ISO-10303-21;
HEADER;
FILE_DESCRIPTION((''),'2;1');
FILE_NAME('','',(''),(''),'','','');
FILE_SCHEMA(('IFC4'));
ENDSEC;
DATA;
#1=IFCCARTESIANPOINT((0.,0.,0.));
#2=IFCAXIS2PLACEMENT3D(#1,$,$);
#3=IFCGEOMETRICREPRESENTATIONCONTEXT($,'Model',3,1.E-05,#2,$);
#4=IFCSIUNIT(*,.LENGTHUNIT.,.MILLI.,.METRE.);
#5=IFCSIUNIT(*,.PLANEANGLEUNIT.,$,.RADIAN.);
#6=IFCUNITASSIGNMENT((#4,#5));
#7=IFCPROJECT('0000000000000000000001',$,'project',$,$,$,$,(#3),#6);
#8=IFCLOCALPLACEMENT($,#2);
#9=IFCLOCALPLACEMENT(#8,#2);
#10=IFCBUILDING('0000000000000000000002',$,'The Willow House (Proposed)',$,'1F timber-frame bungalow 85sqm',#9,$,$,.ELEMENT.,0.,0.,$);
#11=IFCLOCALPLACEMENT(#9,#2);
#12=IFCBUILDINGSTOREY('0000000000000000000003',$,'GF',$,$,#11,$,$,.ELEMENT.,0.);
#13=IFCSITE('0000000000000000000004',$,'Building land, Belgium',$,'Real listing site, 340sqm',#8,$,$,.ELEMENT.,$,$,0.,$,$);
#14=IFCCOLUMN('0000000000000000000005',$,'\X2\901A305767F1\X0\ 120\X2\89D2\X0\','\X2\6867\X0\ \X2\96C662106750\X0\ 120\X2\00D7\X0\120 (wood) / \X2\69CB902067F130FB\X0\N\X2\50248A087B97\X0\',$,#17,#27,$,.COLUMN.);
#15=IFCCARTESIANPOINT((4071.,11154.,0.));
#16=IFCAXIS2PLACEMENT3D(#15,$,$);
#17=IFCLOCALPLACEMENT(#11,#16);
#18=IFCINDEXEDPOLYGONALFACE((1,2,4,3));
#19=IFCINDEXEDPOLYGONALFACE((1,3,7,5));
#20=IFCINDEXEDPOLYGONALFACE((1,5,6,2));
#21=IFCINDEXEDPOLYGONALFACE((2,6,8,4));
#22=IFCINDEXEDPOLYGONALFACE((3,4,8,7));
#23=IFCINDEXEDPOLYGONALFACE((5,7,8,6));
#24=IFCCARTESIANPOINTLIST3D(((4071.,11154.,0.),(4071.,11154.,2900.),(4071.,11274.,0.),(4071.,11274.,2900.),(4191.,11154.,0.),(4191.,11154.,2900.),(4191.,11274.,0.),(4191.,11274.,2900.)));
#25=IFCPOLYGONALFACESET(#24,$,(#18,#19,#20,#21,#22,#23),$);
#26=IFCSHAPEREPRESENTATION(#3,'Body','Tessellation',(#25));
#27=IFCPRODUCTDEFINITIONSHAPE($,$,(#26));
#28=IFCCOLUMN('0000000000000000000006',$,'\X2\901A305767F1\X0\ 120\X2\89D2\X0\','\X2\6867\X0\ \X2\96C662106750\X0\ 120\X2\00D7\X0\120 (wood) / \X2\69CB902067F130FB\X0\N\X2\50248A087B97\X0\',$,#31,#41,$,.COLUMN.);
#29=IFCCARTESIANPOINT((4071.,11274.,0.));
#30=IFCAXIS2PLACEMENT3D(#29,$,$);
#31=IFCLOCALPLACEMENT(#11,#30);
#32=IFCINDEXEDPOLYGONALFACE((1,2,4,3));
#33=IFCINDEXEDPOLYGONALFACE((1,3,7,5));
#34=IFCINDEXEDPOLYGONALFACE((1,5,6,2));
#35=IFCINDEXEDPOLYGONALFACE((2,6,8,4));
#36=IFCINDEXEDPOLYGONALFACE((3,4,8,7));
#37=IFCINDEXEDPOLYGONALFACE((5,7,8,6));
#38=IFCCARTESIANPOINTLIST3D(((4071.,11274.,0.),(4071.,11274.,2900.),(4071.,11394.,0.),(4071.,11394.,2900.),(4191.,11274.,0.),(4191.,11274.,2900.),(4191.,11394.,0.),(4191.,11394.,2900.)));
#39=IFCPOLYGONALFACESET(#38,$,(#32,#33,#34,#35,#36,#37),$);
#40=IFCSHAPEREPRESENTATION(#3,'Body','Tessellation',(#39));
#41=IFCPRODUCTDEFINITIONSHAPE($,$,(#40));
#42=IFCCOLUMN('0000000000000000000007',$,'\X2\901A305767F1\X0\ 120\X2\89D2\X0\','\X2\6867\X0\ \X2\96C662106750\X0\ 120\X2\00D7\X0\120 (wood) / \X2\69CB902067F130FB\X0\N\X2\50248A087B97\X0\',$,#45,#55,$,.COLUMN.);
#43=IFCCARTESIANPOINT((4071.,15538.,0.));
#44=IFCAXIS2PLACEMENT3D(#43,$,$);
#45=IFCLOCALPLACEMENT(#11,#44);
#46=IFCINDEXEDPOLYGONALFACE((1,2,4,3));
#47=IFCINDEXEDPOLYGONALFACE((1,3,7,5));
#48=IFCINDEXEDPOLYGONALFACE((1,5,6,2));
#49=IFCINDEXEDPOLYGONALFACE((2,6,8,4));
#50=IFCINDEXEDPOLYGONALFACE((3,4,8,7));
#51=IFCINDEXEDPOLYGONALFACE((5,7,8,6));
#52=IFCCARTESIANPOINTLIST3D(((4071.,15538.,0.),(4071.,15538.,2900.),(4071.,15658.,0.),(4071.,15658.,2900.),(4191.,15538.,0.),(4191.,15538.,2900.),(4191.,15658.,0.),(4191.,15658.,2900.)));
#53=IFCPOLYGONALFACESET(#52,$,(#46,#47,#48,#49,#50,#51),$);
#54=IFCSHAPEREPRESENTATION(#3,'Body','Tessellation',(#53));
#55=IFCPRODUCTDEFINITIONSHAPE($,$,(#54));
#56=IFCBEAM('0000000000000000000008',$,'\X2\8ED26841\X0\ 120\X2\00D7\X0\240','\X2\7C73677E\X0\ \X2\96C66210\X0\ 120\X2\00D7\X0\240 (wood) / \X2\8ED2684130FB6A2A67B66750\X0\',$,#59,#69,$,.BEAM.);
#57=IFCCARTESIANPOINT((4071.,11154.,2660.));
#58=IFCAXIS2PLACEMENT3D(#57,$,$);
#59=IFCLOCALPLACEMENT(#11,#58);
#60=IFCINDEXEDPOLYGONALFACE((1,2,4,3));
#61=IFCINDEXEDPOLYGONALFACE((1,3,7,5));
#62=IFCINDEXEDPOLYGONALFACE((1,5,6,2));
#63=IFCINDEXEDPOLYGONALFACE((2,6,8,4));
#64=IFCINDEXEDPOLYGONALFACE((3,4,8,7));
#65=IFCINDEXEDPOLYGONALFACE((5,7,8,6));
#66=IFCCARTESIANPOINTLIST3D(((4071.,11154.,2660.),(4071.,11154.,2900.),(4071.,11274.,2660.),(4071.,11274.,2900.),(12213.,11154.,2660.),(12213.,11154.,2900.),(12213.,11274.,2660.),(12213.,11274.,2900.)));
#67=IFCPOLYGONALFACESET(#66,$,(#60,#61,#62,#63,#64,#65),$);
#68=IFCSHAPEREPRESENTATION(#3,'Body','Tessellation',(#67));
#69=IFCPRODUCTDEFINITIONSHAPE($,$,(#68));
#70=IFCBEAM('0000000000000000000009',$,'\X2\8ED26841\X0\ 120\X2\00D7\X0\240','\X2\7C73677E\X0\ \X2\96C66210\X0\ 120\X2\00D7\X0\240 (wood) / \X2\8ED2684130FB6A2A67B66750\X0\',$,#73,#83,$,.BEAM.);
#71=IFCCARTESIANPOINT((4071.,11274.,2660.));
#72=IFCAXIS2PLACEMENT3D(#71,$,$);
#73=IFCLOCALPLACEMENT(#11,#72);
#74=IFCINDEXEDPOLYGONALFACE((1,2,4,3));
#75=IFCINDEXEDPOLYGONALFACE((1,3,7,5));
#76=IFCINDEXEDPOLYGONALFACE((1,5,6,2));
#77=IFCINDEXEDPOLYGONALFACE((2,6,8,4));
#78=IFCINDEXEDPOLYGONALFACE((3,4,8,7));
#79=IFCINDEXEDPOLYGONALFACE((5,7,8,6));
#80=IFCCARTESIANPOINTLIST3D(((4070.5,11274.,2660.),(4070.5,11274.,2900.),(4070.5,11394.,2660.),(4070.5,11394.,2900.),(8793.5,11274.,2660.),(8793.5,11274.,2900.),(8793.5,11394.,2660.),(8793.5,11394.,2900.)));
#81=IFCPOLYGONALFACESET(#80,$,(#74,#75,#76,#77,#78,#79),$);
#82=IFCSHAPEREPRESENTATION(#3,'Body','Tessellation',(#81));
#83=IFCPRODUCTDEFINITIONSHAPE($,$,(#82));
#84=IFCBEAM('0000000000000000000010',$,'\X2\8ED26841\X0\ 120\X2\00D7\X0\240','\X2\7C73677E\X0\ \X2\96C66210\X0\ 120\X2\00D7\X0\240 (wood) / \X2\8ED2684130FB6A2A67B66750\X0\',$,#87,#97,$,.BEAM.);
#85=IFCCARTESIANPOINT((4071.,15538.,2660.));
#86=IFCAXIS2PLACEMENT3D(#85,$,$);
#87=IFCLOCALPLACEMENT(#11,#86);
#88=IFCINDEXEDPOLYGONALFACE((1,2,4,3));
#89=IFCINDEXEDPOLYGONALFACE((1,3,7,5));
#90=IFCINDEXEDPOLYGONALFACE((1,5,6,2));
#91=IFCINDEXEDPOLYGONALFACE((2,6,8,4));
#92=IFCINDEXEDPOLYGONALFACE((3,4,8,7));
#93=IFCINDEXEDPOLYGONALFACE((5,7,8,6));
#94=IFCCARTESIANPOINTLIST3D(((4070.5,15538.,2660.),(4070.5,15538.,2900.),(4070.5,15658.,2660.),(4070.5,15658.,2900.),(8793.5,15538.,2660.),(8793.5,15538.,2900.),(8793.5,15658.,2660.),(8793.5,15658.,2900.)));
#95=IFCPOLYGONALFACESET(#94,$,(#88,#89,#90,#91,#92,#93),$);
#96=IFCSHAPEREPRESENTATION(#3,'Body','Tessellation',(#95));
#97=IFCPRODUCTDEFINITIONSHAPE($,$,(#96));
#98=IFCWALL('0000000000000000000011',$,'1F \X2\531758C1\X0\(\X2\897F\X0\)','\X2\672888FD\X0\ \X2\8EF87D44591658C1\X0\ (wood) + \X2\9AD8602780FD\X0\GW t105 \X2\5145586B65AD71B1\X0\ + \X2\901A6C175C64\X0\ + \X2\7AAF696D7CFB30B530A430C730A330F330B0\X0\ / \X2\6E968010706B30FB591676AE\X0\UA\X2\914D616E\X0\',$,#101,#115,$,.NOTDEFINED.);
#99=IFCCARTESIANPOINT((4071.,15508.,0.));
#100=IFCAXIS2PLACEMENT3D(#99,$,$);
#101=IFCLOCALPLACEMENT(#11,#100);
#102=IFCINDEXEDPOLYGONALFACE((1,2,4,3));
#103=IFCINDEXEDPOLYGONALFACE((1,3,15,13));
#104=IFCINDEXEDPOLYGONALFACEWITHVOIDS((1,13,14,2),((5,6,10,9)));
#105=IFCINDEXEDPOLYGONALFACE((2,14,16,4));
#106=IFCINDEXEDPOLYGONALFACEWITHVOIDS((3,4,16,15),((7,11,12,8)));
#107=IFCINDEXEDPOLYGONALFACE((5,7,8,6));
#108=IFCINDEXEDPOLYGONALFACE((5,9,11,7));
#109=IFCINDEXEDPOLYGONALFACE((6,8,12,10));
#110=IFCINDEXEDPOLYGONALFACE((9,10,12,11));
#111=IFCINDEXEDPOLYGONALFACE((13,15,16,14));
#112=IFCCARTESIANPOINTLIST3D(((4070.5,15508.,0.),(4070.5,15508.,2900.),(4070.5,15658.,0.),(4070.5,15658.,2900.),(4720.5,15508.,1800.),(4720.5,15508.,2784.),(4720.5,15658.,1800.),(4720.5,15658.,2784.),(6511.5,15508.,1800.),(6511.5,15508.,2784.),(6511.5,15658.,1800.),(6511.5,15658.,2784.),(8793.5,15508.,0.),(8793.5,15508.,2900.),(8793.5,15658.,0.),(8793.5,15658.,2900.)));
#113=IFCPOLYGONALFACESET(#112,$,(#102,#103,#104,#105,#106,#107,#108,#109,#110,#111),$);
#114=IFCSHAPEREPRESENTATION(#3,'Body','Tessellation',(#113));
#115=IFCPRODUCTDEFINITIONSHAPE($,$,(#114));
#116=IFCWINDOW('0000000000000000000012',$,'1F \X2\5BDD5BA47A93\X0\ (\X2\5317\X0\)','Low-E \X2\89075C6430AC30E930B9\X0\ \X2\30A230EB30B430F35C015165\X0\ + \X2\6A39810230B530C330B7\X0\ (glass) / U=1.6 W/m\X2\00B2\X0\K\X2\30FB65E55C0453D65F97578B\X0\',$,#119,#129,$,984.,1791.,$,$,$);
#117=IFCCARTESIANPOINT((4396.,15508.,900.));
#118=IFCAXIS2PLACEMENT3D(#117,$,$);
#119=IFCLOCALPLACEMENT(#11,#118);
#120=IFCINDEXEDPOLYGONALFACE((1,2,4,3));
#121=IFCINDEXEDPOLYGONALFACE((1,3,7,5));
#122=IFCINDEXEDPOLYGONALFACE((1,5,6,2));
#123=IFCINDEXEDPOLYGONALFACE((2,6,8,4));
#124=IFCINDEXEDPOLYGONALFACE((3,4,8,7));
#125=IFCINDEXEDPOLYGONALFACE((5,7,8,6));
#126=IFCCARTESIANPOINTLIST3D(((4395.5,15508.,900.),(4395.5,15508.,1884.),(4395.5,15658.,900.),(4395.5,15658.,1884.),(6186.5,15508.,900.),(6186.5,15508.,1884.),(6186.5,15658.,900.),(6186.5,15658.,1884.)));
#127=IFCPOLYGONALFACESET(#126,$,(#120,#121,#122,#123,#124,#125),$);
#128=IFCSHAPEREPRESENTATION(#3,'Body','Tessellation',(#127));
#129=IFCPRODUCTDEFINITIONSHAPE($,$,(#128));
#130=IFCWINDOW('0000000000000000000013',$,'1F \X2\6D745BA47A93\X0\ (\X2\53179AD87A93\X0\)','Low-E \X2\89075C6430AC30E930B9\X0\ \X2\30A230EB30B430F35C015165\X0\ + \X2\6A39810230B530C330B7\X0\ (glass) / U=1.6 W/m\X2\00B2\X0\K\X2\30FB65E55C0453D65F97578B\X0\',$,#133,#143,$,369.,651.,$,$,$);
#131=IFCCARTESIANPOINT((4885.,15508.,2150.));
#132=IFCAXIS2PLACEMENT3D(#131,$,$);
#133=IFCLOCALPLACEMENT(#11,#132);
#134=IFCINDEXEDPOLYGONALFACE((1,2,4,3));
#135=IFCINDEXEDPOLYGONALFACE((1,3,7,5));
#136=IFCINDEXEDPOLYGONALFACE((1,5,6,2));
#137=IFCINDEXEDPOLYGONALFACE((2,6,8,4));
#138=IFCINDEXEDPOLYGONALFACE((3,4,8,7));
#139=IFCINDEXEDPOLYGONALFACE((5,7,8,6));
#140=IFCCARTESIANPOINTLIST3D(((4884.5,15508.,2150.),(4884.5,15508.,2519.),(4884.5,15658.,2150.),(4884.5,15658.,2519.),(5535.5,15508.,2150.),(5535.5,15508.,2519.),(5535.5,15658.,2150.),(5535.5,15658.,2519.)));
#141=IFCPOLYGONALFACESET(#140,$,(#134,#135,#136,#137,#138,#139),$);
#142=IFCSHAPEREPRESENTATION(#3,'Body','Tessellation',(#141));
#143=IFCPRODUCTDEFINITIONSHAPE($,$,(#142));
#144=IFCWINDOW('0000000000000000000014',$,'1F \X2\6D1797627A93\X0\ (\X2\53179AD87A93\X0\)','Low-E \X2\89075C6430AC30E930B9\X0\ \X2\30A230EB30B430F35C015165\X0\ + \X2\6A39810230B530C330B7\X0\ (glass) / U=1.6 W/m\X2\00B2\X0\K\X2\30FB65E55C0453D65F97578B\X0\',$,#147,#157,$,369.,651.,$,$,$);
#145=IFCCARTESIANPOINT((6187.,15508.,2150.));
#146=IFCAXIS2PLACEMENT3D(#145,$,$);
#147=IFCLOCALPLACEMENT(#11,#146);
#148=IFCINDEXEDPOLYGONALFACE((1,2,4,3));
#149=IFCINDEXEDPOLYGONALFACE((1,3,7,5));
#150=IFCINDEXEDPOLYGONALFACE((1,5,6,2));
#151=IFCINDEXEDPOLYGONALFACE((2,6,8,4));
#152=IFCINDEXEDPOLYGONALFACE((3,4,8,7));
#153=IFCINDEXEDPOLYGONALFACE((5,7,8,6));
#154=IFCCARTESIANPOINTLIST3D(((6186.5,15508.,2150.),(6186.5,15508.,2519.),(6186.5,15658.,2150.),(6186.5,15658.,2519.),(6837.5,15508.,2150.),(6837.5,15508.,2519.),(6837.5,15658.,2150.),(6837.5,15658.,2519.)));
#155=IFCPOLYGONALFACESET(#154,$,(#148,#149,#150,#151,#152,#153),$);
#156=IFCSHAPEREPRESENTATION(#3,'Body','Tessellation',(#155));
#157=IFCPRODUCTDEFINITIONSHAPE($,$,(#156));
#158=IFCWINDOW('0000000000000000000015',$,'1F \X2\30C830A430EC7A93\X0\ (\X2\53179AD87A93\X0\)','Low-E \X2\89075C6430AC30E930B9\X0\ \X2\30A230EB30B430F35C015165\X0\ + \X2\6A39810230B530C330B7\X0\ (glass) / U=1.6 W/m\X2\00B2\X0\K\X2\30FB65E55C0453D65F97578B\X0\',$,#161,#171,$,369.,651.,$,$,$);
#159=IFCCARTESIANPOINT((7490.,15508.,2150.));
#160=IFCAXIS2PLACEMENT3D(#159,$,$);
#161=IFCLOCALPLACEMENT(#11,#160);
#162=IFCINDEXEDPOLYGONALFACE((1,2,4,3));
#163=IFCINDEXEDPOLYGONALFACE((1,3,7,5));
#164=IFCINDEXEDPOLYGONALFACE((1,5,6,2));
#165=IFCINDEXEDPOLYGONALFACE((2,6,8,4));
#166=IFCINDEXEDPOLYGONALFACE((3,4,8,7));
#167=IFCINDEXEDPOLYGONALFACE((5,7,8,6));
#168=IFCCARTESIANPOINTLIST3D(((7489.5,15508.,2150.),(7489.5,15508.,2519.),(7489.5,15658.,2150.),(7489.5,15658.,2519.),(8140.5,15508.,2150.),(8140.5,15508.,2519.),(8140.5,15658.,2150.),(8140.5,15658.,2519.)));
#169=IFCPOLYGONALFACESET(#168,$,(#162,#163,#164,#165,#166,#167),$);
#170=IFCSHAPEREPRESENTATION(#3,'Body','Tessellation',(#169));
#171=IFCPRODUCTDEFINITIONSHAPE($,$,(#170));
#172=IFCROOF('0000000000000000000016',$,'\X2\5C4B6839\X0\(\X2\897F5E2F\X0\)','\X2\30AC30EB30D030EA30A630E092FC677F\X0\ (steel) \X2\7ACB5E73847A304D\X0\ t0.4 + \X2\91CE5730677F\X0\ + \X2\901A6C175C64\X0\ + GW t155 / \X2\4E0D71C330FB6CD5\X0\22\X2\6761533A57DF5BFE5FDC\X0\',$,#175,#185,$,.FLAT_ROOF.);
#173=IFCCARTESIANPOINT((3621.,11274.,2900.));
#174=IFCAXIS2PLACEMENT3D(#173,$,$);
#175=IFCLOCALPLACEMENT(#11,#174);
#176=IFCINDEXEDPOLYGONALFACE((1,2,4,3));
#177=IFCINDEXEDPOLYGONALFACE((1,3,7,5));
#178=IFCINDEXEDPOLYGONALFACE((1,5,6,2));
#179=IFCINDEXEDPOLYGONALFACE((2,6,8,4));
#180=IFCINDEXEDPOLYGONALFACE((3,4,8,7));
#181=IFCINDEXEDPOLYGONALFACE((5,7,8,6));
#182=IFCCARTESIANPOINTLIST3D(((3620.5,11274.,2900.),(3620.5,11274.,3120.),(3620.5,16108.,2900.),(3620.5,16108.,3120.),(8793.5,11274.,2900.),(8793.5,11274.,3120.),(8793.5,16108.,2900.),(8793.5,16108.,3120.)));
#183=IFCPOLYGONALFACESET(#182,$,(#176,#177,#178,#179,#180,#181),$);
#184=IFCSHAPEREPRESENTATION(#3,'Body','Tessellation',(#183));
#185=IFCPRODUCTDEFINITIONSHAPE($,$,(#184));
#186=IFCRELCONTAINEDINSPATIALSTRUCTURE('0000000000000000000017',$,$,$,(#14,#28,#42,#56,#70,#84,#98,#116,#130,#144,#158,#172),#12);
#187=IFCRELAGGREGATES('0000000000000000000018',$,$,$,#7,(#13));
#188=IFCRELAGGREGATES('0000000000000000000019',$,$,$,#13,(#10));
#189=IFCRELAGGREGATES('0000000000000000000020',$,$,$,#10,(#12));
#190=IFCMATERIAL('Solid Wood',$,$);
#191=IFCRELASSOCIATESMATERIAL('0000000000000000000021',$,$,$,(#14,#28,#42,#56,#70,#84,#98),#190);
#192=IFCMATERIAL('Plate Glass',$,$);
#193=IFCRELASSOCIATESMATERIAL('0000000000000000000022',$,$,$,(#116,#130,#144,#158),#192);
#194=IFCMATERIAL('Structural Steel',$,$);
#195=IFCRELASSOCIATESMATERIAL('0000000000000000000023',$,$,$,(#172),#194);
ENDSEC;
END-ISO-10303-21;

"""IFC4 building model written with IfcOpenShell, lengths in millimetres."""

from ifc_helpers import new_model, si_unit, frame, frame_2d, origin, place, context, project, spatial, rectangle, extrude, material, element, fill, save


model = new_model("IFC4")

# Units and contexts
model_context = context("Model", 3, precision=1e-05, world=origin())
ifc_project = project(units=[si_unit("LENGTHUNIT", "METRE", prefix="MILLI"), si_unit("PLANEANGLEUNIT", "RADIAN")], contexts=[model_context])

# Site, building, storey
site_placement = place(None, origin())
site = spatial("IfcSite", under=ifc_project, at=site_placement, Name="Building land, Belgium", ObjectType="Real listing site, 340sqm", CompositionType="ELEMENT", RefElevation=0.0)
building_placement = place(site_placement, origin())
building = spatial("IfcBuilding", under=site, at=building_placement, Name="The Willow House (Proposed)", ObjectType="1F timber-frame bungalow 85sqm", CompositionType="ELEMENT", ElevationOfRefHeight=0.0, ElevationOfTerrain=0.0)
storey_placement = place(building_placement, origin())
storey = spatial("IfcBuildingStorey", under=building, at=storey_placement, Name="GF", CompositionType="ELEMENT", Elevation=0.0)

# Columns
ifc_material_1 = material(Name="Solid Wood")
column_1_placement = place(storey_placement, frame((4071.0, 11154.0, 0.0)))
element("IfcColumn", 1, at=column_1_placement, inside=storey, material=ifc_material_1, Name="通し柱 120角", Description="桧 集成材 120×120 (wood) / 構造柱・N値計算", PredefinedType="COLUMN", context=model_context, shape_type="SweptSolid", body=[
    extrude(rectangle(XDim=120.0, YDim=120.0, at=frame_2d((60.0, 60.0))), frame((4071.0, 11154.0, 0.0)), (0.0, 0.0, 1.0), 2900.0),
])
column_2_placement = place(storey_placement, frame((4071.0, 11274.0, 0.0)))
element("IfcColumn", 2, at=column_2_placement, inside=storey, material=ifc_material_1, Name="通し柱 120角", Description="桧 集成材 120×120 (wood) / 構造柱・N値計算", PredefinedType="COLUMN", context=model_context, shape_type="SweptSolid", body=[
    extrude(rectangle(XDim=120.0, YDim=120.0, at=frame_2d((60.0, 60.0))), frame((4071.0, 11274.0, 0.0)), (0.0, 0.0, 1.0), 2900.0),
])
column_3_placement = place(storey_placement, frame((4071.0, 15538.0, 0.0)))
element("IfcColumn", 3, at=column_3_placement, inside=storey, material=ifc_material_1, Name="通し柱 120角", Description="桧 集成材 120×120 (wood) / 構造柱・N値計算", PredefinedType="COLUMN", context=model_context, shape_type="SweptSolid", body=[
    extrude(rectangle(XDim=120.0, YDim=120.0, at=frame_2d((60.0, 60.0))), frame((4071.0, 15538.0, 0.0)), (0.0, 0.0, 1.0), 2900.0),
])

# Beams
beam_1_placement = place(storey_placement, frame((4071.0, 11154.0, 2660.0)))
element("IfcBeam", 4, at=beam_1_placement, inside=storey, material=ifc_material_1, Name="軒桁 120×240", Description="米松 集成 120×240 (wood) / 軒桁・横架材", PredefinedType="BEAM", context=model_context, shape_type="SweptSolid", body=[
    extrude(rectangle(XDim=8142.0, YDim=120.0, at=frame_2d((4071.0, 60.0))), frame((4071.0, 11154.0, 2660.0)), (0.0, 0.0, 1.0), 240.0),
])
beam_2_placement = place(storey_placement, frame((4071.0, 11274.0, 2660.0)))
element("IfcBeam", 5, at=beam_2_placement, inside=storey, material=ifc_material_1, Name="軒桁 120×240", Description="米松 集成 120×240 (wood) / 軒桁・横架材", PredefinedType="BEAM", context=model_context, shape_type="SweptSolid", body=[
    extrude(rectangle(XDim=4723.0, YDim=120.0, at=frame_2d((2361.0, 60.0))), frame((4071.0, 11274.0, 2660.0)), (0.0, 0.0, 1.0), 240.0),
])
beam_3_placement = place(storey_placement, frame((4071.0, 15538.0, 2660.0)))
element("IfcBeam", 6, at=beam_3_placement, inside=storey, material=ifc_material_1, Name="軒桁 120×240", Description="米松 集成 120×240 (wood) / 軒桁・横架材", PredefinedType="BEAM", context=model_context, shape_type="SweptSolid", body=[
    extrude(rectangle(XDim=4723.0, YDim=120.0, at=frame_2d((2361.0, 60.0))), frame((4071.0, 15538.0, 2660.0)), (0.0, 0.0, 1.0), 240.0),
])

# Wall, openings, windows
wall_1_placement = place(storey_placement, frame((4071.0, 15508.0, 0.0)))
wall_1 = element("IfcWall", 7, at=wall_1_placement, inside=storey, material=ifc_material_1, Name="1F 北壁(西)", Description="木製 軸組外壁 (wood) + 高性能GW t105 充填断熱 + 通気層 + 窯業系サイディング / 準耐火・外皮UA配慮", PredefinedType="NOTDEFINED", context=model_context, shape_type="SweptSolid", body=[
    extrude(rectangle(XDim=4723.0, YDim=150.0, at=frame_2d((2361.0, 75.0))), frame((4071.0, 15508.0, 0.0)), (0.0, 0.0, 1.0), 2900.0),
])
opening_1_placement = place(storey_placement, frame((4396.0, 15508.0, 900.0)))
opening_1 = element("IfcOpeningElement", 8, at=opening_1_placement, cuts=wall_1, PredefinedType="NOTDEFINED", context=model_context, shape_type="SweptSolid", body=[
    extrude(rectangle(XDim=1791.0, YDim=150.0, at=frame_2d((895.0, 75.0))), frame((4396.0, 15508.0, 900.0)), (0.0, 0.0, 1.0), 984.0),
])
opening_2_placement = place(storey_placement, frame((4885.0, 15508.0, 2150.0)))
opening_2 = element("IfcOpeningElement", 9, at=opening_2_placement, cuts=wall_1, PredefinedType="NOTDEFINED", context=model_context, shape_type="SweptSolid", body=[
    extrude(rectangle(XDim=651.0, YDim=150.0, at=frame_2d((325.0, 75.0))), frame((4885.0, 15508.0, 2150.0)), (0.0, 0.0, 1.0), 369.0),
])
opening_3_placement = place(storey_placement, frame((6187.0, 15508.0, 2150.0)))
opening_3 = element("IfcOpeningElement", 10, at=opening_3_placement, cuts=wall_1, PredefinedType="NOTDEFINED", context=model_context, shape_type="SweptSolid", body=[
    extrude(rectangle(XDim=651.0, YDim=150.0, at=frame_2d((325.0, 75.0))), frame((6187.0, 15508.0, 2150.0)), (0.0, 0.0, 1.0), 369.0),
])
opening_4_placement = place(storey_placement, frame((7490.0, 15508.0, 2150.0)))
opening_4 = element("IfcOpeningElement", 11, at=opening_4_placement, cuts=wall_1, PredefinedType="NOTDEFINED", context=model_context, shape_type="SweptSolid", body=[
    extrude(rectangle(XDim=651.0, YDim=150.0, at=frame_2d((325.0, 75.0))), frame((7490.0, 15508.0, 2150.0)), (0.0, 0.0, 1.0), 369.0),
])
ifc_material_2 = material(Name="Plate Glass")
window_1_placement = place(storey_placement, frame((4396.0, 15508.0, 900.0)))
window_1 = element("IfcWindow", 12, at=window_1_placement, inside=storey, material=ifc_material_2, Name="1F 寝室窓 (北)", Description="Low-E 複層ガラス アルゴン封入 + 樹脂サッシ (glass) / U=1.6 W/m²K・日射取得型", OverallHeight=984.0, OverallWidth=1791.0, context=model_context, shape_type="SweptSolid", body=[
    extrude(rectangle(XDim=1791.0, YDim=150.0, at=frame_2d((895.0, 75.0))), frame((4396.0, 15508.0, 900.0)), (0.0, 0.0, 1.0), 984.0),
])
fill(opening_1, window_1)
window_2_placement = place(storey_placement, frame((4885.0, 15508.0, 2150.0)))
window_2 = element("IfcWindow", 13, at=window_2_placement, inside=storey, material=ifc_material_2, Name="1F 浴室窓 (北高窓)", Description="Low-E 複層ガラス アルゴン封入 + 樹脂サッシ (glass) / U=1.6 W/m²K・日射取得型", OverallHeight=369.0, OverallWidth=651.0, context=model_context, shape_type="SweptSolid", body=[
    extrude(rectangle(XDim=651.0, YDim=150.0, at=frame_2d((325.0, 75.0))), frame((4885.0, 15508.0, 2150.0)), (0.0, 0.0, 1.0), 369.0),
])
fill(opening_2, window_2)
window_3_placement = place(storey_placement, frame((6187.0, 15508.0, 2150.0)))
window_3 = element("IfcWindow", 14, at=window_3_placement, inside=storey, material=ifc_material_2, Name="1F 洗面窓 (北高窓)", Description="Low-E 複層ガラス アルゴン封入 + 樹脂サッシ (glass) / U=1.6 W/m²K・日射取得型", OverallHeight=369.0, OverallWidth=651.0, context=model_context, shape_type="SweptSolid", body=[
    extrude(rectangle(XDim=651.0, YDim=150.0, at=frame_2d((325.0, 75.0))), frame((6187.0, 15508.0, 2150.0)), (0.0, 0.0, 1.0), 369.0),
])
fill(opening_3, window_3)
window_4_placement = place(storey_placement, frame((7490.0, 15508.0, 2150.0)))
window_4 = element("IfcWindow", 15, at=window_4_placement, inside=storey, material=ifc_material_2, Name="1F トイレ窓 (北高窓)", Description="Low-E 複層ガラス アルゴン封入 + 樹脂サッシ (glass) / U=1.6 W/m²K・日射取得型", OverallHeight=369.0, OverallWidth=651.0, context=model_context, shape_type="SweptSolid", body=[
    extrude(rectangle(XDim=651.0, YDim=150.0, at=frame_2d((325.0, 75.0))), frame((7490.0, 15508.0, 2150.0)), (0.0, 0.0, 1.0), 369.0),
])
fill(opening_4, window_4)

# Roof
ifc_material_3 = material(Name="Structural Steel")
roof_placement = place(storey_placement, frame((3621.0, 11274.0, 2900.0)))
element("IfcRoof", 16, at=roof_placement, inside=storey, material=ifc_material_3, Name="屋根(西帯)", Description="ガルバリウム鋼板 (steel) 立平葺き t0.4 + 野地板 + 通気層 + GW t155 / 不燃・法22条区域対応", PredefinedType="FLAT_ROOF", context=model_context, shape_type="SweptSolid", body=[
    extrude(rectangle(XDim=5173.0, YDim=4834.0, at=frame_2d((2586.0, 2417.0))), frame((3621.0, 11274.0, 2900.0)), (0.0, 0.0, 1.0), 220.0),
])

save(model, "model.ifc")
